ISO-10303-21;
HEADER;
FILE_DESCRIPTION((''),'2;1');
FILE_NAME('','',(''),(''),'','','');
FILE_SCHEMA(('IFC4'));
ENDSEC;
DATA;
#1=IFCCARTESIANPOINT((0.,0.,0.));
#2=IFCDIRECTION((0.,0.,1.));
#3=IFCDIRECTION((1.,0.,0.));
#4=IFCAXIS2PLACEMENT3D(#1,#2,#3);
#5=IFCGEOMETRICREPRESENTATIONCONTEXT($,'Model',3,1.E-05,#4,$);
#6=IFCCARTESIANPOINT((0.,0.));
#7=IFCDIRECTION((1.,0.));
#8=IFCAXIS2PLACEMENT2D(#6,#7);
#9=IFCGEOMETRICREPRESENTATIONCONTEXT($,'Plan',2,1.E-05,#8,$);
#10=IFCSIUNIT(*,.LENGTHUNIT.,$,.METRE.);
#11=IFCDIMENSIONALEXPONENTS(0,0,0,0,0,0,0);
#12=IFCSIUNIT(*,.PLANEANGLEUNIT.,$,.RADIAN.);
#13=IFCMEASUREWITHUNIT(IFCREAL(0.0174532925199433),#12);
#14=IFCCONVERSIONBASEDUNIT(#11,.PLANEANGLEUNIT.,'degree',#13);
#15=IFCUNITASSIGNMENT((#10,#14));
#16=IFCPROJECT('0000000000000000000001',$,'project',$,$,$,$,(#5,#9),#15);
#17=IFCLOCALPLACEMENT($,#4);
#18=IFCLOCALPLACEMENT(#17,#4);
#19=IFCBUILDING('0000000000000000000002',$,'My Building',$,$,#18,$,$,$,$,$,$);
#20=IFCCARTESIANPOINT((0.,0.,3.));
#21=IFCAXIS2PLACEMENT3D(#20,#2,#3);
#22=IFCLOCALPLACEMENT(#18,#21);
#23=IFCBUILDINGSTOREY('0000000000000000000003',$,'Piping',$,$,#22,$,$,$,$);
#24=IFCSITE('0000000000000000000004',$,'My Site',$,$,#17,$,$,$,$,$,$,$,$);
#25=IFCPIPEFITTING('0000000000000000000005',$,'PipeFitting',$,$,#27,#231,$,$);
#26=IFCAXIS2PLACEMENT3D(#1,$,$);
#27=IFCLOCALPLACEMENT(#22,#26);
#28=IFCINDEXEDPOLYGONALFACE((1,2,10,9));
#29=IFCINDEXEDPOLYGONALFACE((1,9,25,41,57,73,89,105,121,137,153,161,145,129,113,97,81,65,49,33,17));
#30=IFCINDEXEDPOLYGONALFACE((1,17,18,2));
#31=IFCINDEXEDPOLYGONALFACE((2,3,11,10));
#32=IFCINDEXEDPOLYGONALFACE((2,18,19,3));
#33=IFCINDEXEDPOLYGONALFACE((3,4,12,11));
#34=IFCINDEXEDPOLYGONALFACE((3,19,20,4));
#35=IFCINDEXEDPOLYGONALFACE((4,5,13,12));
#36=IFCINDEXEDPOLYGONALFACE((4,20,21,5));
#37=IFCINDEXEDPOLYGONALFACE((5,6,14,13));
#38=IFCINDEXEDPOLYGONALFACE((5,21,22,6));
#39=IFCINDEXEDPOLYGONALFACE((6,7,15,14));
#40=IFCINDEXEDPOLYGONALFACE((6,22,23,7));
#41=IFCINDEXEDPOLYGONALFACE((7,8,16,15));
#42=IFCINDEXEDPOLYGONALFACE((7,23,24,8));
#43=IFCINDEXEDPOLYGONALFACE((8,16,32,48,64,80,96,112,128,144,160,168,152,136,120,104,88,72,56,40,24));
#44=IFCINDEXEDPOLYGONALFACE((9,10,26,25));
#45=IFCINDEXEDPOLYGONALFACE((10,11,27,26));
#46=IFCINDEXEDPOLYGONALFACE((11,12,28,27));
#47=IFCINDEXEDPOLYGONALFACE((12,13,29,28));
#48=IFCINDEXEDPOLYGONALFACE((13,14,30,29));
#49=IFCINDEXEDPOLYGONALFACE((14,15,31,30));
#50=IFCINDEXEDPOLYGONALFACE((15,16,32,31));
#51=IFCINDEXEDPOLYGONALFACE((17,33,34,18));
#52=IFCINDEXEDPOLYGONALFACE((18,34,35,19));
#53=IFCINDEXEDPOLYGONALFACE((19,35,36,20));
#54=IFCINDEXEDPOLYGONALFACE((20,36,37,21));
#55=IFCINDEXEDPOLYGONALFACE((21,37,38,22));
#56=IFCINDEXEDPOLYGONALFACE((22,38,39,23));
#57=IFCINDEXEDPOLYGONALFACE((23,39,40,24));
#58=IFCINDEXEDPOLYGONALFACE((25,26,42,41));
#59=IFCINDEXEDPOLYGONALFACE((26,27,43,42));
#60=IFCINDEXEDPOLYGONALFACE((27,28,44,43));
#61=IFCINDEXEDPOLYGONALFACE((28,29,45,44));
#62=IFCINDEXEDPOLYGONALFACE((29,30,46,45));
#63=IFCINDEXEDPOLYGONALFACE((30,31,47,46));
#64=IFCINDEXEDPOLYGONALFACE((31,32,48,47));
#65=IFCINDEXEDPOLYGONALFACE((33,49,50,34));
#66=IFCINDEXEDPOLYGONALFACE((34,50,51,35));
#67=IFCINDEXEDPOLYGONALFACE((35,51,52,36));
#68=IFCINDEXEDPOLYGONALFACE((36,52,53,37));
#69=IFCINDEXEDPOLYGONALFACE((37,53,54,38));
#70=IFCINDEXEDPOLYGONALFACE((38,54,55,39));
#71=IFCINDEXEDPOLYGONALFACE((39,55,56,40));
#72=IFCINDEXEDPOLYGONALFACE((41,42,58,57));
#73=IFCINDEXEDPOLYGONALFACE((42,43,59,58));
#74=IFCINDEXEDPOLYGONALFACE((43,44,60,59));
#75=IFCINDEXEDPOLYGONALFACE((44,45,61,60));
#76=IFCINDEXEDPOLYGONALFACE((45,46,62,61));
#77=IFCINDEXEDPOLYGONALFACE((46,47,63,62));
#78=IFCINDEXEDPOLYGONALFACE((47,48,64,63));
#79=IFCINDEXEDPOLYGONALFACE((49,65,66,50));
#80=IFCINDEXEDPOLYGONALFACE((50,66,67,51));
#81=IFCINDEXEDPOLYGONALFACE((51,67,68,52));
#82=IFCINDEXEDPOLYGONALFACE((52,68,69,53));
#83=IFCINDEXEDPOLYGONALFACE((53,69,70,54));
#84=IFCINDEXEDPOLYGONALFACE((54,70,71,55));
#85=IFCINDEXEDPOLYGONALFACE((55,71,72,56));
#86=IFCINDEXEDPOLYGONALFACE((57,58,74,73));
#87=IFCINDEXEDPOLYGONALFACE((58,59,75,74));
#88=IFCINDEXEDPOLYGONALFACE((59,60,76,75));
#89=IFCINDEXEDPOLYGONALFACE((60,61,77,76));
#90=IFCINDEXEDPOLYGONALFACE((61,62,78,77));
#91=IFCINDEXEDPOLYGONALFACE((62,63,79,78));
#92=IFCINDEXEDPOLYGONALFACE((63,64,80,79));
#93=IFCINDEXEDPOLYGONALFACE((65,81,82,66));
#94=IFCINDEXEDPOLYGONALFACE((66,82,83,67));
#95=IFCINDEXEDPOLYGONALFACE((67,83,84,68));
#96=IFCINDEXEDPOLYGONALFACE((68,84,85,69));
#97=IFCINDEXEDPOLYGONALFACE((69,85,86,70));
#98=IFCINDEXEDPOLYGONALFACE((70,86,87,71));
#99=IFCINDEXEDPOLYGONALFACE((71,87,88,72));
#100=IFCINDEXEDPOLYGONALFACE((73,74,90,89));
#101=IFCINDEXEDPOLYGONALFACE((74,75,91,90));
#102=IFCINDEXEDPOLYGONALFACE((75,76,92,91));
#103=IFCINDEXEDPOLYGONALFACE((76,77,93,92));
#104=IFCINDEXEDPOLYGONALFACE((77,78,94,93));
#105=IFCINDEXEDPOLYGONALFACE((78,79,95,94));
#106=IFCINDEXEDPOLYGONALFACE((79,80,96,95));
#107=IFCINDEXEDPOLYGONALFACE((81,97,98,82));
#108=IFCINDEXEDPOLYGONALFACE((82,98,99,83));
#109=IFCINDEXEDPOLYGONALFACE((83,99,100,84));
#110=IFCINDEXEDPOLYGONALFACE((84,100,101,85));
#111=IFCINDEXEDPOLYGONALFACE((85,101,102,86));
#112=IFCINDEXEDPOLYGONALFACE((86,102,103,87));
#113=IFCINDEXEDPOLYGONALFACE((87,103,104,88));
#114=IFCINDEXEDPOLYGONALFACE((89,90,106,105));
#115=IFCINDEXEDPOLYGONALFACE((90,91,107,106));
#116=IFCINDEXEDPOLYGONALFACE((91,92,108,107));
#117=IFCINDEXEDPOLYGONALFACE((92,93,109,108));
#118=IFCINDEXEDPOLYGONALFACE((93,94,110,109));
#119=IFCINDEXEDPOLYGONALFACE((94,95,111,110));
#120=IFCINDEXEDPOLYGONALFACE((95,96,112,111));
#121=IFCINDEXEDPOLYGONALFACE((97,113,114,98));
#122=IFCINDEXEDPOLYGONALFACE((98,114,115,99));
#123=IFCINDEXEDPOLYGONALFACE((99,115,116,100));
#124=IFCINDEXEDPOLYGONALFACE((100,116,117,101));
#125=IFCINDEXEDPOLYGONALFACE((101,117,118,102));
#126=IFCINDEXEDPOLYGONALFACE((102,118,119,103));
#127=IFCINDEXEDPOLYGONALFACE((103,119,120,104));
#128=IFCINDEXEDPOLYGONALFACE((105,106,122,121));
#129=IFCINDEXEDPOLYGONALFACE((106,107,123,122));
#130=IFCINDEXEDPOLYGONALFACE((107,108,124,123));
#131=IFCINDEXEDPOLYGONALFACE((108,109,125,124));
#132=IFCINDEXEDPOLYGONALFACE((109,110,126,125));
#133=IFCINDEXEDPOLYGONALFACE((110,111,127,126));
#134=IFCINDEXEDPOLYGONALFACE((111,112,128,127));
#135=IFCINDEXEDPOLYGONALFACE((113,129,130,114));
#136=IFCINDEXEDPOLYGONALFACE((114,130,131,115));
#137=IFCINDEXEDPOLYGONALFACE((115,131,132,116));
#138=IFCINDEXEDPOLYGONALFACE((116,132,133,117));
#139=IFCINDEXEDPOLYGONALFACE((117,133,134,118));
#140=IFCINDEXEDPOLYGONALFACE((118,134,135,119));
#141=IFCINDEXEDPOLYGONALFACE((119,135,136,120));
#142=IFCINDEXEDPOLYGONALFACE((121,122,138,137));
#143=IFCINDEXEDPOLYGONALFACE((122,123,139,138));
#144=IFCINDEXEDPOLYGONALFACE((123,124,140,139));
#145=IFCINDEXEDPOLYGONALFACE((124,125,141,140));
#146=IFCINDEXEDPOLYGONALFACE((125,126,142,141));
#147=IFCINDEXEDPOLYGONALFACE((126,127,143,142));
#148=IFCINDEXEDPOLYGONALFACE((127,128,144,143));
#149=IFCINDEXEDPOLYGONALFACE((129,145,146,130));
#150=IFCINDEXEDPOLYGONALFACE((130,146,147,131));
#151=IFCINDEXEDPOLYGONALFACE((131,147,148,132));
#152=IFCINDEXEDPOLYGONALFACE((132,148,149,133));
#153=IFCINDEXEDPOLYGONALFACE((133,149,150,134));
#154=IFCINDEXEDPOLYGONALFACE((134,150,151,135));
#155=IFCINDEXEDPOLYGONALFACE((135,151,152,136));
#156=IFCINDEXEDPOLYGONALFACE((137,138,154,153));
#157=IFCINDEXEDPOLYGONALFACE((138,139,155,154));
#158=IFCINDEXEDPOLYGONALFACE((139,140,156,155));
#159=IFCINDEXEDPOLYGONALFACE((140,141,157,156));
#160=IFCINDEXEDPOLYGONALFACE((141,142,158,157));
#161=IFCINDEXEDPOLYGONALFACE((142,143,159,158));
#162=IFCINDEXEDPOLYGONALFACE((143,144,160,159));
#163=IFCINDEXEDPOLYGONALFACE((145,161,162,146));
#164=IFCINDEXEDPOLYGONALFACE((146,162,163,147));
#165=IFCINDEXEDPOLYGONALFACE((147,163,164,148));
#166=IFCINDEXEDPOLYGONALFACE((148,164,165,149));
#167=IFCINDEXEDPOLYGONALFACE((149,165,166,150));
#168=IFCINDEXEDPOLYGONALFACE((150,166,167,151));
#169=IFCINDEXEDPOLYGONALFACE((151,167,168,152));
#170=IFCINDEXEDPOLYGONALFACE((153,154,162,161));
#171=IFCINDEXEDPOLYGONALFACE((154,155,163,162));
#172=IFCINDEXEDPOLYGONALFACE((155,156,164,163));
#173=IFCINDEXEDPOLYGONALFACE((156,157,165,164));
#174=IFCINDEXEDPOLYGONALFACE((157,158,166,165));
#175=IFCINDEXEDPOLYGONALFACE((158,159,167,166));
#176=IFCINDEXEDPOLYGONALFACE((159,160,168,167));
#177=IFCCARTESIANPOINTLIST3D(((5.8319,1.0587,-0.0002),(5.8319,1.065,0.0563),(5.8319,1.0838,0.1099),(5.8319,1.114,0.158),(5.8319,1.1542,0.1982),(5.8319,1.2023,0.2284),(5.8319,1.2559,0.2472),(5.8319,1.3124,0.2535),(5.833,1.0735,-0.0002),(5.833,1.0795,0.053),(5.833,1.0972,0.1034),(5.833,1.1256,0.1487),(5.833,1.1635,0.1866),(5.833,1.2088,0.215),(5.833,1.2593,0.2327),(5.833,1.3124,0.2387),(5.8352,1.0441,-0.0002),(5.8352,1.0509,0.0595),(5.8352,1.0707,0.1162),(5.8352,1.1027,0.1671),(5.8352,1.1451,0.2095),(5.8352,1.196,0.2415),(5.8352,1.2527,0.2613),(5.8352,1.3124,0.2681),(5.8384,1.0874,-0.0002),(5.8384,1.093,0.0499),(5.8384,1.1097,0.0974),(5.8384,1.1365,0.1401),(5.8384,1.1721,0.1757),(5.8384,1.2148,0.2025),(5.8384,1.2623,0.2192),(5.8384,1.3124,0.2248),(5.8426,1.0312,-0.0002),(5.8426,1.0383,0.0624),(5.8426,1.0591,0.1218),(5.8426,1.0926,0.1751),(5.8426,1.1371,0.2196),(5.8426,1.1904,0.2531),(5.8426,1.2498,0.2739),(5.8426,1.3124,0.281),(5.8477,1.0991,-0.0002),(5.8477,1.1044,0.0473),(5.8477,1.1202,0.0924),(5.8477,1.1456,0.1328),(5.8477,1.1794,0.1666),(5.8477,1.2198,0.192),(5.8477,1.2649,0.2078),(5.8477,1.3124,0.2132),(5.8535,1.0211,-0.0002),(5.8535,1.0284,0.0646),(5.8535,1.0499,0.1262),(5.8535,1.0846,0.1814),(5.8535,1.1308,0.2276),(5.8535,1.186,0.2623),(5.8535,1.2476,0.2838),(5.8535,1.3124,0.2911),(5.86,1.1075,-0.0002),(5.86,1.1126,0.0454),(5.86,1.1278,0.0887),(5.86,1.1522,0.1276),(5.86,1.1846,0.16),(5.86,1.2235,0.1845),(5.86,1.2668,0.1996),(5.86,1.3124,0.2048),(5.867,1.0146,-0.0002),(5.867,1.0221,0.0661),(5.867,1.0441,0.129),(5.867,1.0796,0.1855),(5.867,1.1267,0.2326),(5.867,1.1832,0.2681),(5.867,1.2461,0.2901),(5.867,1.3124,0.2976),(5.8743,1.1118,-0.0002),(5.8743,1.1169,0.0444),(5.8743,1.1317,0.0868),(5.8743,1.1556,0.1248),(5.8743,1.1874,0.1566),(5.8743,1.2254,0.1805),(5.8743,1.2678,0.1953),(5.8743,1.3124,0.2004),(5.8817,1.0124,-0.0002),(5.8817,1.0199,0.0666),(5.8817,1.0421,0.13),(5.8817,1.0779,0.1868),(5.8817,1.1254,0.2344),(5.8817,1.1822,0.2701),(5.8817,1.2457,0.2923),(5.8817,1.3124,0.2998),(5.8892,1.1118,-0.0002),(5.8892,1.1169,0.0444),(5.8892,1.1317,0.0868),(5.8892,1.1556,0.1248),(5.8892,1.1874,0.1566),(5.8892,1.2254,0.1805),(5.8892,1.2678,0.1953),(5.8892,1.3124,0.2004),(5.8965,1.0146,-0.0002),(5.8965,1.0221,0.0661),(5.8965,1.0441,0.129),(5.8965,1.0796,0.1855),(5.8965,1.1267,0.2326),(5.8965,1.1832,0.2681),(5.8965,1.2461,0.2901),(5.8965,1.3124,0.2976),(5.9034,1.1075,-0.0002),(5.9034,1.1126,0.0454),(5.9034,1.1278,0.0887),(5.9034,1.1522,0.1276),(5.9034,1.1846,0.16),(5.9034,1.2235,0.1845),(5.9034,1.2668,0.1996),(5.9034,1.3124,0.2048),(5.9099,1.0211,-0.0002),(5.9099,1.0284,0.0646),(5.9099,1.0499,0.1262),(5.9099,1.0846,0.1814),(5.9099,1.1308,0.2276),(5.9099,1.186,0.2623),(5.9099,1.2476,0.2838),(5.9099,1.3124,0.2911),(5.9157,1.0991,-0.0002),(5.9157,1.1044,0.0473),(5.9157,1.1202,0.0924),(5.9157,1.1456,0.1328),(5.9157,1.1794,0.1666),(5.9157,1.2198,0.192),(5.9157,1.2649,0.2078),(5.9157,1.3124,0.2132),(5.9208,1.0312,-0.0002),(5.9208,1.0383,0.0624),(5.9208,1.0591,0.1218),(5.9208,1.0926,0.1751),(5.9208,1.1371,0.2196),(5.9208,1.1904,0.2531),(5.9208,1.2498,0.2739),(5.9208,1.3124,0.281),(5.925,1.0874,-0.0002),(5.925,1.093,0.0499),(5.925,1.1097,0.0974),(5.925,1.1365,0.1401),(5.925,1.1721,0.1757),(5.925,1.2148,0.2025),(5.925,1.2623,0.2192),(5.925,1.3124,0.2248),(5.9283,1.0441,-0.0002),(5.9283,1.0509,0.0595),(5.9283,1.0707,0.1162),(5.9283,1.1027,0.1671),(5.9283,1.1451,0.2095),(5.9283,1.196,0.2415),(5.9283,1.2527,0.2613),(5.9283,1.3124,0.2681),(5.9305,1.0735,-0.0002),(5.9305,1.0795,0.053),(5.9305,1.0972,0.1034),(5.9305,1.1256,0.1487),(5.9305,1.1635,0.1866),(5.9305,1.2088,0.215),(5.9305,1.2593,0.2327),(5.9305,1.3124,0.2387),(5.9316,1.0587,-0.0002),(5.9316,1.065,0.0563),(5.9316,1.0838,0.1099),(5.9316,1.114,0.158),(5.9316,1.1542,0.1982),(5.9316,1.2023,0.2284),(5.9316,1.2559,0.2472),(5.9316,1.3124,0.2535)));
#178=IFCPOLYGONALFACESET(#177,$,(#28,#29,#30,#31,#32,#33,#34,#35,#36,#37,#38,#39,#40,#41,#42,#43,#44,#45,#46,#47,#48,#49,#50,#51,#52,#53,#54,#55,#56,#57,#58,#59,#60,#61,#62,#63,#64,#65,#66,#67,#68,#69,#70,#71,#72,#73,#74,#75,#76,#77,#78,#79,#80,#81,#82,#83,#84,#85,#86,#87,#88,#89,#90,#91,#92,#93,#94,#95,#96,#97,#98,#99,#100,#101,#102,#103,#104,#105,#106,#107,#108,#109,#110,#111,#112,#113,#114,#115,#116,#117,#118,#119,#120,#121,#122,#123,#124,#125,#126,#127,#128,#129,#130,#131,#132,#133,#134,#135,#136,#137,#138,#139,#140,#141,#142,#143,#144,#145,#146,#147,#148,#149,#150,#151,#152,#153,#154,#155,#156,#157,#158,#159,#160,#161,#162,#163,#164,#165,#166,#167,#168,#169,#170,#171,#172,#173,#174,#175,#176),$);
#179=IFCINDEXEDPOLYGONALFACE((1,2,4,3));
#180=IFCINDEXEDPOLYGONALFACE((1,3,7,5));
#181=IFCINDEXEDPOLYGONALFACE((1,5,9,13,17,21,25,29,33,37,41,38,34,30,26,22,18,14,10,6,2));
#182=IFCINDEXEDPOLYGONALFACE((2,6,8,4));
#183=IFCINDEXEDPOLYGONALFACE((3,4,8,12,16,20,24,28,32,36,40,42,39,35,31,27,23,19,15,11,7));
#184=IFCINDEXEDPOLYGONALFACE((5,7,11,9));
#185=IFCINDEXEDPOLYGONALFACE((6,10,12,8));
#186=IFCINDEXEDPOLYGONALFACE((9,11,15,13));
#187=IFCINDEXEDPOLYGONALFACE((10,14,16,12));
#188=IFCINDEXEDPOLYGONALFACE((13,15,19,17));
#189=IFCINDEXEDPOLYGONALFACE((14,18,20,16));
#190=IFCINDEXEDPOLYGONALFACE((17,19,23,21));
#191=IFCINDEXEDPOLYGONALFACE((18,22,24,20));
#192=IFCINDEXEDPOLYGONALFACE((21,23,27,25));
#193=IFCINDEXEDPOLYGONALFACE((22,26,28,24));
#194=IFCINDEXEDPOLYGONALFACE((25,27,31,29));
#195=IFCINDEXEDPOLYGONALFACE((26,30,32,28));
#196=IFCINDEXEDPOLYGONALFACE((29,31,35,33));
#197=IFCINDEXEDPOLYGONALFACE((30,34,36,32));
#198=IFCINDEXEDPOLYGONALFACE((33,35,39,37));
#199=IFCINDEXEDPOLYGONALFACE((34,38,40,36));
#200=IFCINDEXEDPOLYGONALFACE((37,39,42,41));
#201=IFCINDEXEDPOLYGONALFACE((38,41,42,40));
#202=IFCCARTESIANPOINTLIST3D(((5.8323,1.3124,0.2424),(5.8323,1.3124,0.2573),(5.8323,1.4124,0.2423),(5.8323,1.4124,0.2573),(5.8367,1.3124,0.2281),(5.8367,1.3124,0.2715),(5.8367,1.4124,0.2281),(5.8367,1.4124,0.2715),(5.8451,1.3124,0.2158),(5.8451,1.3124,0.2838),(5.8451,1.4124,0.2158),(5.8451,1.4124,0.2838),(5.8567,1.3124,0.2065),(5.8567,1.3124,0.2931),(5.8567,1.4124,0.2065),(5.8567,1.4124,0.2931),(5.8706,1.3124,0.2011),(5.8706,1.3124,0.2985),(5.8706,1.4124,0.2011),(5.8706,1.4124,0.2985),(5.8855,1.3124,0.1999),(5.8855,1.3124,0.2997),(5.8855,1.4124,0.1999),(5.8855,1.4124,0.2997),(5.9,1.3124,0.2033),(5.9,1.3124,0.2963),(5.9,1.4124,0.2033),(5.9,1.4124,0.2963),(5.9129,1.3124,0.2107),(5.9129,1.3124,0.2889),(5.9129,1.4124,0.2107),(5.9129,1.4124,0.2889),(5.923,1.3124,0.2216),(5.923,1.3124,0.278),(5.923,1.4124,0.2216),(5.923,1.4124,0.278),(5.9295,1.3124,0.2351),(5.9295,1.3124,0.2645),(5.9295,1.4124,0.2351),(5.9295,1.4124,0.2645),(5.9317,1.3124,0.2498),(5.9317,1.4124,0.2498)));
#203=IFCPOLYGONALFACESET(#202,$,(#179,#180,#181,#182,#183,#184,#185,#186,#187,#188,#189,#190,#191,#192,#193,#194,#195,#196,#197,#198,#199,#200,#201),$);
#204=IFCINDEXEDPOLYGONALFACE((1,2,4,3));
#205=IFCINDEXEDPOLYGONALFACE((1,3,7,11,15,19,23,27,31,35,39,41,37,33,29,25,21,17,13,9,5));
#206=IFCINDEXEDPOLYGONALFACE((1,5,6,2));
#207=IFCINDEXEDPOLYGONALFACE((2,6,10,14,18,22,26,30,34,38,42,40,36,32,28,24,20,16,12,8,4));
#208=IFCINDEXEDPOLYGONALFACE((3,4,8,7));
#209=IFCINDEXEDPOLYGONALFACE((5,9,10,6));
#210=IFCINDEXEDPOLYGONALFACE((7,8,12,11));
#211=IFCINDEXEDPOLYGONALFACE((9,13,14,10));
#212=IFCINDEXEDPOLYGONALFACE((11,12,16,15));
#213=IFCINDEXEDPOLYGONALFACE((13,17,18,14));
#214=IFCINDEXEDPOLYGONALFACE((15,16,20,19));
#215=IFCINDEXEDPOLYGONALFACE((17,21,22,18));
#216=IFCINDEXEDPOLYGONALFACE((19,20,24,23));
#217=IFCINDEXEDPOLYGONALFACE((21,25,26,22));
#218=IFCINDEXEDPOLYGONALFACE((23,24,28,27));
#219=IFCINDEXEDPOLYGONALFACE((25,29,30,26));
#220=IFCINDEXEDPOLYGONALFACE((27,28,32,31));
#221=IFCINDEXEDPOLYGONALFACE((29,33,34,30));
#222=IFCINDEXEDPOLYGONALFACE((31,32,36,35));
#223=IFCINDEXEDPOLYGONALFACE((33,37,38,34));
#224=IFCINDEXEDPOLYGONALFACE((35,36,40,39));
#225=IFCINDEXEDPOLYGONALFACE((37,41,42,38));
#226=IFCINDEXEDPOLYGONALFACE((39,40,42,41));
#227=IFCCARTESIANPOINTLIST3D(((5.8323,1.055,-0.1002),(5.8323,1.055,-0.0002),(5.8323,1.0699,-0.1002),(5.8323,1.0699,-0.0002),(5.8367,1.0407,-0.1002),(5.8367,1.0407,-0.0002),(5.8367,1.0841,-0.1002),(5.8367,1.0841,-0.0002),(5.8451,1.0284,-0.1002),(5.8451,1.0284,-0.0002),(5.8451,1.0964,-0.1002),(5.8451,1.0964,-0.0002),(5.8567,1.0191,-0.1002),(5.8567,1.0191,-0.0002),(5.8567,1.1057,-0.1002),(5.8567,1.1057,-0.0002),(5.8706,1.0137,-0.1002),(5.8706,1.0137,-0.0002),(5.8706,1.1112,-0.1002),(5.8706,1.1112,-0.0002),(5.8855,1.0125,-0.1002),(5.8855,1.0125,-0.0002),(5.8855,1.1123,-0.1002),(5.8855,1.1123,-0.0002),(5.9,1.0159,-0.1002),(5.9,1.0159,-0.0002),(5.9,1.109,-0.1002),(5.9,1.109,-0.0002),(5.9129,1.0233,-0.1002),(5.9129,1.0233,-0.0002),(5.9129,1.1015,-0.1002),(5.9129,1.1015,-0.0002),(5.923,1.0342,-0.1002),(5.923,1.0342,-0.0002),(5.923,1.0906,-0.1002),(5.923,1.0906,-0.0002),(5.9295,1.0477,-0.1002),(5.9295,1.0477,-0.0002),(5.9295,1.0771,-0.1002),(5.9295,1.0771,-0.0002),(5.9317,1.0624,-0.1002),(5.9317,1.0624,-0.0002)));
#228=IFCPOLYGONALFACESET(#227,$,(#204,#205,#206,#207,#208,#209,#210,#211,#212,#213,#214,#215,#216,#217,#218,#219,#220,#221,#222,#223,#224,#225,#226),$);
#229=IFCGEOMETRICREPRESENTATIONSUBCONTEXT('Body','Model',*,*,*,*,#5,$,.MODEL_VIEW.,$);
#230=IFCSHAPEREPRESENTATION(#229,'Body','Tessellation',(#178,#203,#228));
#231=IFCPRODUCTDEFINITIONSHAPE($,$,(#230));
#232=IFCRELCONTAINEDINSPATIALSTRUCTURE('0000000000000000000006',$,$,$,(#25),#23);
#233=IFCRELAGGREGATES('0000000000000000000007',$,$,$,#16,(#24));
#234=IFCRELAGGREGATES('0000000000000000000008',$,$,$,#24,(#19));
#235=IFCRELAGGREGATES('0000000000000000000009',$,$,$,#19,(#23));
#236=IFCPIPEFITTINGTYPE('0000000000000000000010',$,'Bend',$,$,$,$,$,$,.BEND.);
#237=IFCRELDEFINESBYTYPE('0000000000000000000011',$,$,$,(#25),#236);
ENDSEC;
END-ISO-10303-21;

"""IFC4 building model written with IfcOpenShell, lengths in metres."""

from ifc_helpers import new_model, entity, si_unit, converted_unit, frame, origin_with_axes, origin_2d_with_axis, place, context, subcontext, project, spatial, circle, extrude, source, transform, mapped, type_object, type_shapes, element, save


model = new_model("IFC4")

# Units and contexts
model_context = context("Model", 3, precision=1e-05, world=origin_with_axes())
plan_context = context("Plan", 2, precision=1e-05, world=origin_2d_with_axis())
body_context = subcontext(model_context, "Body", "Model", "MODEL_VIEW")
ifc_project = project(units=[si_unit("LENGTHUNIT", "METRE"), converted_unit("PLANEANGLEUNIT", "degree", entity("IfcReal", 0.0174532925199433), si_unit("PLANEANGLEUNIT", "RADIAN"), dimensions=[0, 0, 0, 0, 0, 0, 0])], contexts=[model_context, plan_context])

# Site, building, storey
site_placement = place(None, origin_with_axes())
site = spatial("IfcSite", under=ifc_project, at=site_placement, Name="My Site")
building_placement = place(site_placement, origin_with_axes())
building = spatial("IfcBuilding", under=site, at=building_placement, Name="My Building")
storey_placement = place(building_placement, frame((0.0, 0.0, 3.0), z_axis=(0.0, 0.0, 1.0), x_axis=(1.0, 0.0, 0.0)))
storey = spatial("IfcBuildingStorey", under=building, at=storey_placement, Name="Piping")

# Pipe fitting
pipe_fitting_type_1 = type_object("IfcPipeFittingType", Name="Bend", PredefinedType="BEND")
shared_shape = source(origin_with_axes(), body_context, "Body", "SolidModel", [
    entity("IfcSweptDiskSolid", entity("IfcIndexedPolyCurve", entity("IfcCartesianPointList3D", [[0.0, 0.0, 0.1], [0.0, -0.0732, 0.2768], [0.0, -0.25, 0.35]]), [entity("IfcArcIndex", [1, 2, 3])]), 0.05),
    extrude(circle(Radius=0.05), origin_with_axes(), (0.0, 0.0, 1.0), 0.1),
    extrude(circle(Radius=0.05), frame((0.0, -0.25, 0.35), z_axis=(0.0, -1.0, -0.00003), x_axis=(1.0, 0.0, 0.0)), (0.0, 0.0, 1.0), 0.1),
])
type_shapes(pipe_fitting_type_1, [shared_shape])
for number, where, z_axis, x_axis, name in (
    (1, (5.8817, 1.4124, 0.2498), (0.0, -1.0, 0.000008), (1.0, 0.0, 0.0), "PipeFitting"),
):
    element("IfcPipeFitting", number, at=place(storey_placement, frame(where, z_axis=z_axis, x_axis=x_axis)), inside=storey, type_object=pipe_fitting_type_1, Name=name, context=body_context, shape_type="MappedRepresentation", body=[
        mapped(shared_shape, transform((0.0, 0.0, 0.0), x_axis=(1.0, 0.0, 0.0), y_axis=(0.0, 1.0, 0.0), z_axis=(0.0, 0.0, 1.0), scale=1.0)),
    ])

save(model, "model.ifc")
